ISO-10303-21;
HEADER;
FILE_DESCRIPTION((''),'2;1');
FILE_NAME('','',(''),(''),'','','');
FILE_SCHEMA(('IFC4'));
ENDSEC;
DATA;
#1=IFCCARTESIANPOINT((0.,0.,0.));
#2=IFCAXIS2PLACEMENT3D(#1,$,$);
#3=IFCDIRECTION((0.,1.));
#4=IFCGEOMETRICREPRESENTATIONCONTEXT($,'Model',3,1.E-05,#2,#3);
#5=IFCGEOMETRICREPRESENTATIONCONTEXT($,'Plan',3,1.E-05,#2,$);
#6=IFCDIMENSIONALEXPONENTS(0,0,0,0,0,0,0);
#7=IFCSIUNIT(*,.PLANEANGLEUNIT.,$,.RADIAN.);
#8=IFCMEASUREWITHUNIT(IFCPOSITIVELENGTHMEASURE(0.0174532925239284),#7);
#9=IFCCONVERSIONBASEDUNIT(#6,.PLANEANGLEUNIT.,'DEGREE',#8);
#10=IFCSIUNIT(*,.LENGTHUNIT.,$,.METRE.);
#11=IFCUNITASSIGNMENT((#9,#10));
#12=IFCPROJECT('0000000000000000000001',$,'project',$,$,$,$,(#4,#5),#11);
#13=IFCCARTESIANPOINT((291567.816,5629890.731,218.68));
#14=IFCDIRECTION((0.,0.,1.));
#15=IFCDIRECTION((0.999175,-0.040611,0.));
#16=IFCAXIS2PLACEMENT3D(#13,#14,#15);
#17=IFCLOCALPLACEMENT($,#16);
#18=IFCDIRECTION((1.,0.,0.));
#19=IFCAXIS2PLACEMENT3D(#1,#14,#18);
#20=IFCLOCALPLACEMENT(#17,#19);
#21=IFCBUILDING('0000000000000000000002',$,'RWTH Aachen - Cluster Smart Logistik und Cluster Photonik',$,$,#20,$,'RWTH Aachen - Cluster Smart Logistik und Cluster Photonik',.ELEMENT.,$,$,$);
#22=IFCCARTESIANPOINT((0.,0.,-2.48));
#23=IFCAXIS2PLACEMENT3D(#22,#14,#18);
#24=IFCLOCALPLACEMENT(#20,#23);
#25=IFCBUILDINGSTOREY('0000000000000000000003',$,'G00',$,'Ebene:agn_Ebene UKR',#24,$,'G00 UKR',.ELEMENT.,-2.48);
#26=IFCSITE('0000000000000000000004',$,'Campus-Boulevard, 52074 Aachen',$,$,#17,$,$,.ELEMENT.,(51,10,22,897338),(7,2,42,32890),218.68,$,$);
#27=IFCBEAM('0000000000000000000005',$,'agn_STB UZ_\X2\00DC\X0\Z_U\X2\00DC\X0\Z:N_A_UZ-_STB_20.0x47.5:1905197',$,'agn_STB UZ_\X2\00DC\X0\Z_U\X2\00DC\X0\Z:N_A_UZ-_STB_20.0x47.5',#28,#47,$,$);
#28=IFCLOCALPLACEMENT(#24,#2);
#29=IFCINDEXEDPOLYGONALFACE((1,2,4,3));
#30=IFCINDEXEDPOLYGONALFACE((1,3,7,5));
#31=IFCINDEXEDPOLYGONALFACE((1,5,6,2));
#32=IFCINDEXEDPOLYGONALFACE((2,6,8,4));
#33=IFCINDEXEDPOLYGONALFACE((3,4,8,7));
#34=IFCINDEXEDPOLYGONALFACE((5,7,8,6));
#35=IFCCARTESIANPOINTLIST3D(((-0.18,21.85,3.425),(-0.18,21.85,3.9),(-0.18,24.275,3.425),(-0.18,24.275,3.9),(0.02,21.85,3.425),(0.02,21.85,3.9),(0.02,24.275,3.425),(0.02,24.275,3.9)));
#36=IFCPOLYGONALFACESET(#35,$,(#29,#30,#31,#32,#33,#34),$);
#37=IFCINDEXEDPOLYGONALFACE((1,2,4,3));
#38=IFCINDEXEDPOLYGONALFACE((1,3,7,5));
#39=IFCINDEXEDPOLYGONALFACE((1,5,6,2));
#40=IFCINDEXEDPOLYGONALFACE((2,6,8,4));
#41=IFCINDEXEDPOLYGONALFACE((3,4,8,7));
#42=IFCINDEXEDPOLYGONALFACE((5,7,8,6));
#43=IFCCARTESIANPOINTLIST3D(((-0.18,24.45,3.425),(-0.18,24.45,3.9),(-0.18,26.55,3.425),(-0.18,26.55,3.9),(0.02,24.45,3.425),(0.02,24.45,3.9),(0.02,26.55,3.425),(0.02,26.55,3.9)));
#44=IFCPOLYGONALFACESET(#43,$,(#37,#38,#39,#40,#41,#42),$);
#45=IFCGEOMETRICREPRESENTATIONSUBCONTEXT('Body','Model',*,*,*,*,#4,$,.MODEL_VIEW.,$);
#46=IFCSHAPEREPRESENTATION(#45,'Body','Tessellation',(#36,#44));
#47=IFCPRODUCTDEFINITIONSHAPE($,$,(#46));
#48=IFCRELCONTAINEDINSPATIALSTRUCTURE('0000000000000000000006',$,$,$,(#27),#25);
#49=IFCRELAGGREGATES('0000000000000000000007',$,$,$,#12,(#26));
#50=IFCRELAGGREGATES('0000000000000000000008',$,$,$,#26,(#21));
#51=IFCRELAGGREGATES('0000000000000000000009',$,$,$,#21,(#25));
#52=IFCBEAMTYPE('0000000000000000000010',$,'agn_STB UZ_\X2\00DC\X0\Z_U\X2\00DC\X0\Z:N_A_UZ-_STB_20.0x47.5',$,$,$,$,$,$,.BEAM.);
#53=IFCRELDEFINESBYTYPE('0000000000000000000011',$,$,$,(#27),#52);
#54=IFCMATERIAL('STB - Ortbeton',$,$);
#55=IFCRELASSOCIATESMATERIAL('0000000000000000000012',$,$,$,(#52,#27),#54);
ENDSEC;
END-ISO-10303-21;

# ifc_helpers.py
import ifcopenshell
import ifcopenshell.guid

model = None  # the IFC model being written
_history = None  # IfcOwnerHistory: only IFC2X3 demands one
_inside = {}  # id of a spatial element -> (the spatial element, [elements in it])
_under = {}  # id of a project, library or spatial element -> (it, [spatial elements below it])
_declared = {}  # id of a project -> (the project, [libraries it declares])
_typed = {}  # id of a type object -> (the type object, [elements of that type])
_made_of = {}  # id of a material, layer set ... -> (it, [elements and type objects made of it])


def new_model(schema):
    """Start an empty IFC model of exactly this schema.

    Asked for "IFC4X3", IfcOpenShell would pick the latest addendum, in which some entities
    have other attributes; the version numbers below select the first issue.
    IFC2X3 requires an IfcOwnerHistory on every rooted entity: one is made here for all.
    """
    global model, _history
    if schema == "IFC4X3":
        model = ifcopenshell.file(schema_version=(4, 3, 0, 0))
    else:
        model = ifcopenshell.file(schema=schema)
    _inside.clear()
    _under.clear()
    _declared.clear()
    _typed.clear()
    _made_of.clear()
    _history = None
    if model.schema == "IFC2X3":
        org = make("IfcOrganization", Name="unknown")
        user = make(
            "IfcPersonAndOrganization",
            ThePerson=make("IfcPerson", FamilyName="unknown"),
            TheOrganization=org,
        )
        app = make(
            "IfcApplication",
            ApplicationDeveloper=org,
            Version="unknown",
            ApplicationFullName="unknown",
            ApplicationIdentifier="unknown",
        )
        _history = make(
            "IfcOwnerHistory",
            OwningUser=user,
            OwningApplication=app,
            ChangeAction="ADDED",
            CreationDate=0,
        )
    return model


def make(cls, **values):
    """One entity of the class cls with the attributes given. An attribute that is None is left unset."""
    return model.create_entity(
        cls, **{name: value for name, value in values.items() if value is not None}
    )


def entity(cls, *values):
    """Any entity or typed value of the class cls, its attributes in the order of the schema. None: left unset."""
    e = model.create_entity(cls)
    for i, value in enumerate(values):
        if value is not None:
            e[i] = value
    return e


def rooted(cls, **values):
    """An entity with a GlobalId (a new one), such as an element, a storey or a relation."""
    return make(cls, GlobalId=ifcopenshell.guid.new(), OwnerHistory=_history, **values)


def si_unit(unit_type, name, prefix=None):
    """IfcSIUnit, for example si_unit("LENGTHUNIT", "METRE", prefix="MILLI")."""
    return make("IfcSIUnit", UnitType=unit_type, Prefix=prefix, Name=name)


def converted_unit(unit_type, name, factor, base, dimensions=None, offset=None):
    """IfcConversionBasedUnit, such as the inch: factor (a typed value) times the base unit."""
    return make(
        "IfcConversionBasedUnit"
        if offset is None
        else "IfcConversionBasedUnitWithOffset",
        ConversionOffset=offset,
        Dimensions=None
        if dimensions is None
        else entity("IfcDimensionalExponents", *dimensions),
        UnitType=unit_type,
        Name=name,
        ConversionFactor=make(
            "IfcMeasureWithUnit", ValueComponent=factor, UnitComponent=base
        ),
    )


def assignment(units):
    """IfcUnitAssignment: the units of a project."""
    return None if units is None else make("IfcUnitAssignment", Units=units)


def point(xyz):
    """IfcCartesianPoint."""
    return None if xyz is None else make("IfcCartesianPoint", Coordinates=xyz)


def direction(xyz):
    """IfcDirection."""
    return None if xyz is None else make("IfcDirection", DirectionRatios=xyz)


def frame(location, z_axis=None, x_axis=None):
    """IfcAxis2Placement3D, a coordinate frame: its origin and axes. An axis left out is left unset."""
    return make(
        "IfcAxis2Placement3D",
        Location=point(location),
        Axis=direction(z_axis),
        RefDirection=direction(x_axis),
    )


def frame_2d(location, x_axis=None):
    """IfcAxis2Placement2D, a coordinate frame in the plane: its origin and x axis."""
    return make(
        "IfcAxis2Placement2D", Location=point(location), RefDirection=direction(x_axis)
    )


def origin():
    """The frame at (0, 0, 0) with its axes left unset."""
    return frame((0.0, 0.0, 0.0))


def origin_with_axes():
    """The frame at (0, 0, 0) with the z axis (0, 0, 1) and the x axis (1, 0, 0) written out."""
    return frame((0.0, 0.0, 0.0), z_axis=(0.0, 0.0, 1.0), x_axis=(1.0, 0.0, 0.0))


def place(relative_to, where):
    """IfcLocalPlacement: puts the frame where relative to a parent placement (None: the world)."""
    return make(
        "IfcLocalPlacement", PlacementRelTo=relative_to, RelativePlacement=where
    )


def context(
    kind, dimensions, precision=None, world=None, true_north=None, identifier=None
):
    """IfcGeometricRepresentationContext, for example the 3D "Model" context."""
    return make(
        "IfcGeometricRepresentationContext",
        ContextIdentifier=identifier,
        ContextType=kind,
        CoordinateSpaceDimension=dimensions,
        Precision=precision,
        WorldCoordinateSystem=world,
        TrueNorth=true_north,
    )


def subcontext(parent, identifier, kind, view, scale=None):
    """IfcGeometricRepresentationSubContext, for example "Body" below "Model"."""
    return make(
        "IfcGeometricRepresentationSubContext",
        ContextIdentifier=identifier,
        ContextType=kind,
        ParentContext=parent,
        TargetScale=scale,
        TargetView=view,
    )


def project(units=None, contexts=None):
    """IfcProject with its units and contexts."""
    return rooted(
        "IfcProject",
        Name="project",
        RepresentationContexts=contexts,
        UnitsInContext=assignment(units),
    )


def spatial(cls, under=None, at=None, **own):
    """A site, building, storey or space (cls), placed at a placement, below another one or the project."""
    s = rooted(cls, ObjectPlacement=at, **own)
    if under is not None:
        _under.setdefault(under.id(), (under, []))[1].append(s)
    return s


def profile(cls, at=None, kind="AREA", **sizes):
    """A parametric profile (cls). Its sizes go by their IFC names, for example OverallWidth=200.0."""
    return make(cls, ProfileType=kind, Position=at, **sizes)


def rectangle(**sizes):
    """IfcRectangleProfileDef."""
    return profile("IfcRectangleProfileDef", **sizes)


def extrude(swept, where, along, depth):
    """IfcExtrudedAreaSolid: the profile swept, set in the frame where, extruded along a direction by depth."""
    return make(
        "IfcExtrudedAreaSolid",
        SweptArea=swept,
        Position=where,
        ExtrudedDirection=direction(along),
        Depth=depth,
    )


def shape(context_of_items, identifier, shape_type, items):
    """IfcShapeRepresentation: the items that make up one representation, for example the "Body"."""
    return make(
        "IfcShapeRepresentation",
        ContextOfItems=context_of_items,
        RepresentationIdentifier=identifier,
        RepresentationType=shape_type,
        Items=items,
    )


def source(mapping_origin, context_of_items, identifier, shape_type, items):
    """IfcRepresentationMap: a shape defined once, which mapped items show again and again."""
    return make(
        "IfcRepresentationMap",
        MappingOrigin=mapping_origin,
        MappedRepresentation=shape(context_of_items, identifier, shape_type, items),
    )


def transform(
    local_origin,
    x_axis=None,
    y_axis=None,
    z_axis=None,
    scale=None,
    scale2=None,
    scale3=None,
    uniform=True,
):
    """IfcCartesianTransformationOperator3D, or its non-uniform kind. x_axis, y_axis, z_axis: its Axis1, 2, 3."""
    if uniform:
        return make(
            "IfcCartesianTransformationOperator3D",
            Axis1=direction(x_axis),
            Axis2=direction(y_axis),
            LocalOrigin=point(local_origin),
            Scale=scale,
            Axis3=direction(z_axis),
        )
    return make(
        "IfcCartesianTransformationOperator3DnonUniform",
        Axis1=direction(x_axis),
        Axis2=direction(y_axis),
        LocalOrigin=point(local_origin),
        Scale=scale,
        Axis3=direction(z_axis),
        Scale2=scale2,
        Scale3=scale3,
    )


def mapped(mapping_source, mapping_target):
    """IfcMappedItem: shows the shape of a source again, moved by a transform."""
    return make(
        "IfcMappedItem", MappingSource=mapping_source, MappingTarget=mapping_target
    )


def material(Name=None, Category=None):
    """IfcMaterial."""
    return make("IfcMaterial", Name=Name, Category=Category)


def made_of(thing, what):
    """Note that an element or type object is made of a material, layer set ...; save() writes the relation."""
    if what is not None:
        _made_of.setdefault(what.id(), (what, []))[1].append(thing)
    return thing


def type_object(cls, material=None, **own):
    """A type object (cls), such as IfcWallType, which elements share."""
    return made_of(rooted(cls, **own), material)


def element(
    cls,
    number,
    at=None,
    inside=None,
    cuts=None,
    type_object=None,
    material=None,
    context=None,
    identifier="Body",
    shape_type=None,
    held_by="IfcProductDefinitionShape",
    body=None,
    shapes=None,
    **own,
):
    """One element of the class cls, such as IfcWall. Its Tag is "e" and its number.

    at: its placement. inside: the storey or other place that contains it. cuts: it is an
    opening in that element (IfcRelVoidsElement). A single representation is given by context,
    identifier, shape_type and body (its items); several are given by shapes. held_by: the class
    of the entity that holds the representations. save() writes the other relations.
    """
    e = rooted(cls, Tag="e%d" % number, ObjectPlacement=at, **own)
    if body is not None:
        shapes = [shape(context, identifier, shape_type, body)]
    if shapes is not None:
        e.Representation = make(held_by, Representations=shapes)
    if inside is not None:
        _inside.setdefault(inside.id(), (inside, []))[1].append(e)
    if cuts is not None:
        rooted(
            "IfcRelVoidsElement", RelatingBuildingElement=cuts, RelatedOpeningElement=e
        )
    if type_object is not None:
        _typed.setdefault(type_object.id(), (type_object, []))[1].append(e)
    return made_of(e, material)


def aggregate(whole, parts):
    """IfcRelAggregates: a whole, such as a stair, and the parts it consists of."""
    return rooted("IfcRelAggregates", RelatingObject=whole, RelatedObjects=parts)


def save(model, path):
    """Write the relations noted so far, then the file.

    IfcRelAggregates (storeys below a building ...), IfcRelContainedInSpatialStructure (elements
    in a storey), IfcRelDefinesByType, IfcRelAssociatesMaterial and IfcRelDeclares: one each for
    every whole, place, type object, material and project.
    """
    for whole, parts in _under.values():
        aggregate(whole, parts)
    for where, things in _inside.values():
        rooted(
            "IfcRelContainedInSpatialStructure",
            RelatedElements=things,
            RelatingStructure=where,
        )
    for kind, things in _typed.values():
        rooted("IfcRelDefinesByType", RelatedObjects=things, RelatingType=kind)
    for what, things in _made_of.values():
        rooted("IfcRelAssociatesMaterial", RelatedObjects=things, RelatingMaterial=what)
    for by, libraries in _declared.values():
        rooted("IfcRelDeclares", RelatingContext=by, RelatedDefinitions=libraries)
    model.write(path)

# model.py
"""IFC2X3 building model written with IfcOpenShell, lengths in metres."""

from ifc_helpers import new_model, entity, si_unit, converted_unit, direction, frame, frame_2d, origin, origin_with_axes, place, context, subcontext, project, spatial, rectangle, extrude, source, transform, mapped, material, type_object, element, save


model = new_model("IFC2X3")

# Units and contexts
model_context = context("Model", 3, precision=1e-05, world=origin(), true_north=direction((0.0, 1.0)))
plan_context = context("Plan", 3, precision=1e-05, world=origin())
body_context = subcontext(model_context, "Body", "Model", "MODEL_VIEW")
ifc_project = project(units=[converted_unit("PLANEANGLEUNIT", "DEGREE", entity("IfcPositiveLengthMeasure", 0.0174532925239284), si_unit("PLANEANGLEUNIT", "RADIAN"), dimensions=[0, 0, 0, 0, 0, 0, 0]), si_unit("LENGTHUNIT", "METRE")], contexts=[model_context, plan_context])

# Site, building, storey
site_placement = place(None, frame((291567.816, 5629890.731, 218.68), z_axis=(0.0, 0.0, 1.0), x_axis=(0.999175, -0.040611, 0.0)))
site = spatial("IfcSite", under=ifc_project, at=site_placement, Name="Campus-Boulevard, 52074 Aachen", CompositionType="ELEMENT", RefLatitude=(51, 10, 22, 897338), RefLongitude=(7, 2, 42, 32890), RefElevation=218.68)
building_placement = place(site_placement, origin_with_axes())
building = spatial("IfcBuilding", under=site, at=building_placement, Name="RWTH Aachen - Cluster Smart Logistik und Cluster Photonik", LongName="RWTH Aachen - Cluster Smart Logistik und Cluster Photonik", CompositionType="ELEMENT")
storey_placement = place(building_placement, frame((0.0, 0.0, -2.48), z_axis=(0.0, 0.0, 1.0), x_axis=(1.0, 0.0, 0.0)))
storey = spatial("IfcBuildingStorey", under=building, at=storey_placement, Name="G00", ObjectType="Ebene:agn_Ebene UKR", LongName="G00 UKR", CompositionType="ELEMENT", Elevation=-2.48)

# Shared definitions
ifc_material = material(Name="STB - Ortbeton")

# Beam
beam_type = type_object("IfcBeamType", Name="agn_STB UZ_ÜZ_UÜZ:N_A_UZ-_STB_20.0x47.5", PredefinedType="BEAM", material=ifc_material)
shared_shape_1 = source(origin(), body_context, "Body", "SweptSolid", [
    extrude(rectangle(XDim=0.475, YDim=0.2, at=frame_2d((0.0, 0.0), x_axis=(0.0, 1.0))), frame((-0.08, 24.275, 1.1825), z_axis=(0.0, -1.0, 0.0), x_axis=(-1.0, 0.0, 0.0)), (0.0, 0.0, 1.0), 2.425),
    extrude(rectangle(XDim=0.475, YDim=0.2, at=frame_2d((0.0, 0.0), x_axis=(0.0, 1.0))), frame((-0.08, 26.55, 1.1825), z_axis=(0.0, -1.0, 0.0), x_axis=(-1.0, 0.0, 0.0)), (0.0, 0.0, 1.0), 2.1),
])
beam_placement = place(storey_placement, frame((0.0, 0.0, 2.48), z_axis=(0.0, 0.0, 1.0), x_axis=(1.0, 0.0, 0.0)))
element("IfcBeam", 1, at=beam_placement, inside=storey, type_object=beam_type, material=ifc_material, Name="agn_STB UZ_ÜZ_UÜZ:N_A_UZ-_STB_20.0x47.5:1905197", ObjectType="agn_STB UZ_ÜZ_UÜZ:N_A_UZ-_STB_20.0x47.5", context=body_context, shape_type="MappedRepresentation", body=[
    mapped(shared_shape_1, transform((0.0, 0.0, 0.0), scale=1.0)),
])

save(model, "model.ifc")
